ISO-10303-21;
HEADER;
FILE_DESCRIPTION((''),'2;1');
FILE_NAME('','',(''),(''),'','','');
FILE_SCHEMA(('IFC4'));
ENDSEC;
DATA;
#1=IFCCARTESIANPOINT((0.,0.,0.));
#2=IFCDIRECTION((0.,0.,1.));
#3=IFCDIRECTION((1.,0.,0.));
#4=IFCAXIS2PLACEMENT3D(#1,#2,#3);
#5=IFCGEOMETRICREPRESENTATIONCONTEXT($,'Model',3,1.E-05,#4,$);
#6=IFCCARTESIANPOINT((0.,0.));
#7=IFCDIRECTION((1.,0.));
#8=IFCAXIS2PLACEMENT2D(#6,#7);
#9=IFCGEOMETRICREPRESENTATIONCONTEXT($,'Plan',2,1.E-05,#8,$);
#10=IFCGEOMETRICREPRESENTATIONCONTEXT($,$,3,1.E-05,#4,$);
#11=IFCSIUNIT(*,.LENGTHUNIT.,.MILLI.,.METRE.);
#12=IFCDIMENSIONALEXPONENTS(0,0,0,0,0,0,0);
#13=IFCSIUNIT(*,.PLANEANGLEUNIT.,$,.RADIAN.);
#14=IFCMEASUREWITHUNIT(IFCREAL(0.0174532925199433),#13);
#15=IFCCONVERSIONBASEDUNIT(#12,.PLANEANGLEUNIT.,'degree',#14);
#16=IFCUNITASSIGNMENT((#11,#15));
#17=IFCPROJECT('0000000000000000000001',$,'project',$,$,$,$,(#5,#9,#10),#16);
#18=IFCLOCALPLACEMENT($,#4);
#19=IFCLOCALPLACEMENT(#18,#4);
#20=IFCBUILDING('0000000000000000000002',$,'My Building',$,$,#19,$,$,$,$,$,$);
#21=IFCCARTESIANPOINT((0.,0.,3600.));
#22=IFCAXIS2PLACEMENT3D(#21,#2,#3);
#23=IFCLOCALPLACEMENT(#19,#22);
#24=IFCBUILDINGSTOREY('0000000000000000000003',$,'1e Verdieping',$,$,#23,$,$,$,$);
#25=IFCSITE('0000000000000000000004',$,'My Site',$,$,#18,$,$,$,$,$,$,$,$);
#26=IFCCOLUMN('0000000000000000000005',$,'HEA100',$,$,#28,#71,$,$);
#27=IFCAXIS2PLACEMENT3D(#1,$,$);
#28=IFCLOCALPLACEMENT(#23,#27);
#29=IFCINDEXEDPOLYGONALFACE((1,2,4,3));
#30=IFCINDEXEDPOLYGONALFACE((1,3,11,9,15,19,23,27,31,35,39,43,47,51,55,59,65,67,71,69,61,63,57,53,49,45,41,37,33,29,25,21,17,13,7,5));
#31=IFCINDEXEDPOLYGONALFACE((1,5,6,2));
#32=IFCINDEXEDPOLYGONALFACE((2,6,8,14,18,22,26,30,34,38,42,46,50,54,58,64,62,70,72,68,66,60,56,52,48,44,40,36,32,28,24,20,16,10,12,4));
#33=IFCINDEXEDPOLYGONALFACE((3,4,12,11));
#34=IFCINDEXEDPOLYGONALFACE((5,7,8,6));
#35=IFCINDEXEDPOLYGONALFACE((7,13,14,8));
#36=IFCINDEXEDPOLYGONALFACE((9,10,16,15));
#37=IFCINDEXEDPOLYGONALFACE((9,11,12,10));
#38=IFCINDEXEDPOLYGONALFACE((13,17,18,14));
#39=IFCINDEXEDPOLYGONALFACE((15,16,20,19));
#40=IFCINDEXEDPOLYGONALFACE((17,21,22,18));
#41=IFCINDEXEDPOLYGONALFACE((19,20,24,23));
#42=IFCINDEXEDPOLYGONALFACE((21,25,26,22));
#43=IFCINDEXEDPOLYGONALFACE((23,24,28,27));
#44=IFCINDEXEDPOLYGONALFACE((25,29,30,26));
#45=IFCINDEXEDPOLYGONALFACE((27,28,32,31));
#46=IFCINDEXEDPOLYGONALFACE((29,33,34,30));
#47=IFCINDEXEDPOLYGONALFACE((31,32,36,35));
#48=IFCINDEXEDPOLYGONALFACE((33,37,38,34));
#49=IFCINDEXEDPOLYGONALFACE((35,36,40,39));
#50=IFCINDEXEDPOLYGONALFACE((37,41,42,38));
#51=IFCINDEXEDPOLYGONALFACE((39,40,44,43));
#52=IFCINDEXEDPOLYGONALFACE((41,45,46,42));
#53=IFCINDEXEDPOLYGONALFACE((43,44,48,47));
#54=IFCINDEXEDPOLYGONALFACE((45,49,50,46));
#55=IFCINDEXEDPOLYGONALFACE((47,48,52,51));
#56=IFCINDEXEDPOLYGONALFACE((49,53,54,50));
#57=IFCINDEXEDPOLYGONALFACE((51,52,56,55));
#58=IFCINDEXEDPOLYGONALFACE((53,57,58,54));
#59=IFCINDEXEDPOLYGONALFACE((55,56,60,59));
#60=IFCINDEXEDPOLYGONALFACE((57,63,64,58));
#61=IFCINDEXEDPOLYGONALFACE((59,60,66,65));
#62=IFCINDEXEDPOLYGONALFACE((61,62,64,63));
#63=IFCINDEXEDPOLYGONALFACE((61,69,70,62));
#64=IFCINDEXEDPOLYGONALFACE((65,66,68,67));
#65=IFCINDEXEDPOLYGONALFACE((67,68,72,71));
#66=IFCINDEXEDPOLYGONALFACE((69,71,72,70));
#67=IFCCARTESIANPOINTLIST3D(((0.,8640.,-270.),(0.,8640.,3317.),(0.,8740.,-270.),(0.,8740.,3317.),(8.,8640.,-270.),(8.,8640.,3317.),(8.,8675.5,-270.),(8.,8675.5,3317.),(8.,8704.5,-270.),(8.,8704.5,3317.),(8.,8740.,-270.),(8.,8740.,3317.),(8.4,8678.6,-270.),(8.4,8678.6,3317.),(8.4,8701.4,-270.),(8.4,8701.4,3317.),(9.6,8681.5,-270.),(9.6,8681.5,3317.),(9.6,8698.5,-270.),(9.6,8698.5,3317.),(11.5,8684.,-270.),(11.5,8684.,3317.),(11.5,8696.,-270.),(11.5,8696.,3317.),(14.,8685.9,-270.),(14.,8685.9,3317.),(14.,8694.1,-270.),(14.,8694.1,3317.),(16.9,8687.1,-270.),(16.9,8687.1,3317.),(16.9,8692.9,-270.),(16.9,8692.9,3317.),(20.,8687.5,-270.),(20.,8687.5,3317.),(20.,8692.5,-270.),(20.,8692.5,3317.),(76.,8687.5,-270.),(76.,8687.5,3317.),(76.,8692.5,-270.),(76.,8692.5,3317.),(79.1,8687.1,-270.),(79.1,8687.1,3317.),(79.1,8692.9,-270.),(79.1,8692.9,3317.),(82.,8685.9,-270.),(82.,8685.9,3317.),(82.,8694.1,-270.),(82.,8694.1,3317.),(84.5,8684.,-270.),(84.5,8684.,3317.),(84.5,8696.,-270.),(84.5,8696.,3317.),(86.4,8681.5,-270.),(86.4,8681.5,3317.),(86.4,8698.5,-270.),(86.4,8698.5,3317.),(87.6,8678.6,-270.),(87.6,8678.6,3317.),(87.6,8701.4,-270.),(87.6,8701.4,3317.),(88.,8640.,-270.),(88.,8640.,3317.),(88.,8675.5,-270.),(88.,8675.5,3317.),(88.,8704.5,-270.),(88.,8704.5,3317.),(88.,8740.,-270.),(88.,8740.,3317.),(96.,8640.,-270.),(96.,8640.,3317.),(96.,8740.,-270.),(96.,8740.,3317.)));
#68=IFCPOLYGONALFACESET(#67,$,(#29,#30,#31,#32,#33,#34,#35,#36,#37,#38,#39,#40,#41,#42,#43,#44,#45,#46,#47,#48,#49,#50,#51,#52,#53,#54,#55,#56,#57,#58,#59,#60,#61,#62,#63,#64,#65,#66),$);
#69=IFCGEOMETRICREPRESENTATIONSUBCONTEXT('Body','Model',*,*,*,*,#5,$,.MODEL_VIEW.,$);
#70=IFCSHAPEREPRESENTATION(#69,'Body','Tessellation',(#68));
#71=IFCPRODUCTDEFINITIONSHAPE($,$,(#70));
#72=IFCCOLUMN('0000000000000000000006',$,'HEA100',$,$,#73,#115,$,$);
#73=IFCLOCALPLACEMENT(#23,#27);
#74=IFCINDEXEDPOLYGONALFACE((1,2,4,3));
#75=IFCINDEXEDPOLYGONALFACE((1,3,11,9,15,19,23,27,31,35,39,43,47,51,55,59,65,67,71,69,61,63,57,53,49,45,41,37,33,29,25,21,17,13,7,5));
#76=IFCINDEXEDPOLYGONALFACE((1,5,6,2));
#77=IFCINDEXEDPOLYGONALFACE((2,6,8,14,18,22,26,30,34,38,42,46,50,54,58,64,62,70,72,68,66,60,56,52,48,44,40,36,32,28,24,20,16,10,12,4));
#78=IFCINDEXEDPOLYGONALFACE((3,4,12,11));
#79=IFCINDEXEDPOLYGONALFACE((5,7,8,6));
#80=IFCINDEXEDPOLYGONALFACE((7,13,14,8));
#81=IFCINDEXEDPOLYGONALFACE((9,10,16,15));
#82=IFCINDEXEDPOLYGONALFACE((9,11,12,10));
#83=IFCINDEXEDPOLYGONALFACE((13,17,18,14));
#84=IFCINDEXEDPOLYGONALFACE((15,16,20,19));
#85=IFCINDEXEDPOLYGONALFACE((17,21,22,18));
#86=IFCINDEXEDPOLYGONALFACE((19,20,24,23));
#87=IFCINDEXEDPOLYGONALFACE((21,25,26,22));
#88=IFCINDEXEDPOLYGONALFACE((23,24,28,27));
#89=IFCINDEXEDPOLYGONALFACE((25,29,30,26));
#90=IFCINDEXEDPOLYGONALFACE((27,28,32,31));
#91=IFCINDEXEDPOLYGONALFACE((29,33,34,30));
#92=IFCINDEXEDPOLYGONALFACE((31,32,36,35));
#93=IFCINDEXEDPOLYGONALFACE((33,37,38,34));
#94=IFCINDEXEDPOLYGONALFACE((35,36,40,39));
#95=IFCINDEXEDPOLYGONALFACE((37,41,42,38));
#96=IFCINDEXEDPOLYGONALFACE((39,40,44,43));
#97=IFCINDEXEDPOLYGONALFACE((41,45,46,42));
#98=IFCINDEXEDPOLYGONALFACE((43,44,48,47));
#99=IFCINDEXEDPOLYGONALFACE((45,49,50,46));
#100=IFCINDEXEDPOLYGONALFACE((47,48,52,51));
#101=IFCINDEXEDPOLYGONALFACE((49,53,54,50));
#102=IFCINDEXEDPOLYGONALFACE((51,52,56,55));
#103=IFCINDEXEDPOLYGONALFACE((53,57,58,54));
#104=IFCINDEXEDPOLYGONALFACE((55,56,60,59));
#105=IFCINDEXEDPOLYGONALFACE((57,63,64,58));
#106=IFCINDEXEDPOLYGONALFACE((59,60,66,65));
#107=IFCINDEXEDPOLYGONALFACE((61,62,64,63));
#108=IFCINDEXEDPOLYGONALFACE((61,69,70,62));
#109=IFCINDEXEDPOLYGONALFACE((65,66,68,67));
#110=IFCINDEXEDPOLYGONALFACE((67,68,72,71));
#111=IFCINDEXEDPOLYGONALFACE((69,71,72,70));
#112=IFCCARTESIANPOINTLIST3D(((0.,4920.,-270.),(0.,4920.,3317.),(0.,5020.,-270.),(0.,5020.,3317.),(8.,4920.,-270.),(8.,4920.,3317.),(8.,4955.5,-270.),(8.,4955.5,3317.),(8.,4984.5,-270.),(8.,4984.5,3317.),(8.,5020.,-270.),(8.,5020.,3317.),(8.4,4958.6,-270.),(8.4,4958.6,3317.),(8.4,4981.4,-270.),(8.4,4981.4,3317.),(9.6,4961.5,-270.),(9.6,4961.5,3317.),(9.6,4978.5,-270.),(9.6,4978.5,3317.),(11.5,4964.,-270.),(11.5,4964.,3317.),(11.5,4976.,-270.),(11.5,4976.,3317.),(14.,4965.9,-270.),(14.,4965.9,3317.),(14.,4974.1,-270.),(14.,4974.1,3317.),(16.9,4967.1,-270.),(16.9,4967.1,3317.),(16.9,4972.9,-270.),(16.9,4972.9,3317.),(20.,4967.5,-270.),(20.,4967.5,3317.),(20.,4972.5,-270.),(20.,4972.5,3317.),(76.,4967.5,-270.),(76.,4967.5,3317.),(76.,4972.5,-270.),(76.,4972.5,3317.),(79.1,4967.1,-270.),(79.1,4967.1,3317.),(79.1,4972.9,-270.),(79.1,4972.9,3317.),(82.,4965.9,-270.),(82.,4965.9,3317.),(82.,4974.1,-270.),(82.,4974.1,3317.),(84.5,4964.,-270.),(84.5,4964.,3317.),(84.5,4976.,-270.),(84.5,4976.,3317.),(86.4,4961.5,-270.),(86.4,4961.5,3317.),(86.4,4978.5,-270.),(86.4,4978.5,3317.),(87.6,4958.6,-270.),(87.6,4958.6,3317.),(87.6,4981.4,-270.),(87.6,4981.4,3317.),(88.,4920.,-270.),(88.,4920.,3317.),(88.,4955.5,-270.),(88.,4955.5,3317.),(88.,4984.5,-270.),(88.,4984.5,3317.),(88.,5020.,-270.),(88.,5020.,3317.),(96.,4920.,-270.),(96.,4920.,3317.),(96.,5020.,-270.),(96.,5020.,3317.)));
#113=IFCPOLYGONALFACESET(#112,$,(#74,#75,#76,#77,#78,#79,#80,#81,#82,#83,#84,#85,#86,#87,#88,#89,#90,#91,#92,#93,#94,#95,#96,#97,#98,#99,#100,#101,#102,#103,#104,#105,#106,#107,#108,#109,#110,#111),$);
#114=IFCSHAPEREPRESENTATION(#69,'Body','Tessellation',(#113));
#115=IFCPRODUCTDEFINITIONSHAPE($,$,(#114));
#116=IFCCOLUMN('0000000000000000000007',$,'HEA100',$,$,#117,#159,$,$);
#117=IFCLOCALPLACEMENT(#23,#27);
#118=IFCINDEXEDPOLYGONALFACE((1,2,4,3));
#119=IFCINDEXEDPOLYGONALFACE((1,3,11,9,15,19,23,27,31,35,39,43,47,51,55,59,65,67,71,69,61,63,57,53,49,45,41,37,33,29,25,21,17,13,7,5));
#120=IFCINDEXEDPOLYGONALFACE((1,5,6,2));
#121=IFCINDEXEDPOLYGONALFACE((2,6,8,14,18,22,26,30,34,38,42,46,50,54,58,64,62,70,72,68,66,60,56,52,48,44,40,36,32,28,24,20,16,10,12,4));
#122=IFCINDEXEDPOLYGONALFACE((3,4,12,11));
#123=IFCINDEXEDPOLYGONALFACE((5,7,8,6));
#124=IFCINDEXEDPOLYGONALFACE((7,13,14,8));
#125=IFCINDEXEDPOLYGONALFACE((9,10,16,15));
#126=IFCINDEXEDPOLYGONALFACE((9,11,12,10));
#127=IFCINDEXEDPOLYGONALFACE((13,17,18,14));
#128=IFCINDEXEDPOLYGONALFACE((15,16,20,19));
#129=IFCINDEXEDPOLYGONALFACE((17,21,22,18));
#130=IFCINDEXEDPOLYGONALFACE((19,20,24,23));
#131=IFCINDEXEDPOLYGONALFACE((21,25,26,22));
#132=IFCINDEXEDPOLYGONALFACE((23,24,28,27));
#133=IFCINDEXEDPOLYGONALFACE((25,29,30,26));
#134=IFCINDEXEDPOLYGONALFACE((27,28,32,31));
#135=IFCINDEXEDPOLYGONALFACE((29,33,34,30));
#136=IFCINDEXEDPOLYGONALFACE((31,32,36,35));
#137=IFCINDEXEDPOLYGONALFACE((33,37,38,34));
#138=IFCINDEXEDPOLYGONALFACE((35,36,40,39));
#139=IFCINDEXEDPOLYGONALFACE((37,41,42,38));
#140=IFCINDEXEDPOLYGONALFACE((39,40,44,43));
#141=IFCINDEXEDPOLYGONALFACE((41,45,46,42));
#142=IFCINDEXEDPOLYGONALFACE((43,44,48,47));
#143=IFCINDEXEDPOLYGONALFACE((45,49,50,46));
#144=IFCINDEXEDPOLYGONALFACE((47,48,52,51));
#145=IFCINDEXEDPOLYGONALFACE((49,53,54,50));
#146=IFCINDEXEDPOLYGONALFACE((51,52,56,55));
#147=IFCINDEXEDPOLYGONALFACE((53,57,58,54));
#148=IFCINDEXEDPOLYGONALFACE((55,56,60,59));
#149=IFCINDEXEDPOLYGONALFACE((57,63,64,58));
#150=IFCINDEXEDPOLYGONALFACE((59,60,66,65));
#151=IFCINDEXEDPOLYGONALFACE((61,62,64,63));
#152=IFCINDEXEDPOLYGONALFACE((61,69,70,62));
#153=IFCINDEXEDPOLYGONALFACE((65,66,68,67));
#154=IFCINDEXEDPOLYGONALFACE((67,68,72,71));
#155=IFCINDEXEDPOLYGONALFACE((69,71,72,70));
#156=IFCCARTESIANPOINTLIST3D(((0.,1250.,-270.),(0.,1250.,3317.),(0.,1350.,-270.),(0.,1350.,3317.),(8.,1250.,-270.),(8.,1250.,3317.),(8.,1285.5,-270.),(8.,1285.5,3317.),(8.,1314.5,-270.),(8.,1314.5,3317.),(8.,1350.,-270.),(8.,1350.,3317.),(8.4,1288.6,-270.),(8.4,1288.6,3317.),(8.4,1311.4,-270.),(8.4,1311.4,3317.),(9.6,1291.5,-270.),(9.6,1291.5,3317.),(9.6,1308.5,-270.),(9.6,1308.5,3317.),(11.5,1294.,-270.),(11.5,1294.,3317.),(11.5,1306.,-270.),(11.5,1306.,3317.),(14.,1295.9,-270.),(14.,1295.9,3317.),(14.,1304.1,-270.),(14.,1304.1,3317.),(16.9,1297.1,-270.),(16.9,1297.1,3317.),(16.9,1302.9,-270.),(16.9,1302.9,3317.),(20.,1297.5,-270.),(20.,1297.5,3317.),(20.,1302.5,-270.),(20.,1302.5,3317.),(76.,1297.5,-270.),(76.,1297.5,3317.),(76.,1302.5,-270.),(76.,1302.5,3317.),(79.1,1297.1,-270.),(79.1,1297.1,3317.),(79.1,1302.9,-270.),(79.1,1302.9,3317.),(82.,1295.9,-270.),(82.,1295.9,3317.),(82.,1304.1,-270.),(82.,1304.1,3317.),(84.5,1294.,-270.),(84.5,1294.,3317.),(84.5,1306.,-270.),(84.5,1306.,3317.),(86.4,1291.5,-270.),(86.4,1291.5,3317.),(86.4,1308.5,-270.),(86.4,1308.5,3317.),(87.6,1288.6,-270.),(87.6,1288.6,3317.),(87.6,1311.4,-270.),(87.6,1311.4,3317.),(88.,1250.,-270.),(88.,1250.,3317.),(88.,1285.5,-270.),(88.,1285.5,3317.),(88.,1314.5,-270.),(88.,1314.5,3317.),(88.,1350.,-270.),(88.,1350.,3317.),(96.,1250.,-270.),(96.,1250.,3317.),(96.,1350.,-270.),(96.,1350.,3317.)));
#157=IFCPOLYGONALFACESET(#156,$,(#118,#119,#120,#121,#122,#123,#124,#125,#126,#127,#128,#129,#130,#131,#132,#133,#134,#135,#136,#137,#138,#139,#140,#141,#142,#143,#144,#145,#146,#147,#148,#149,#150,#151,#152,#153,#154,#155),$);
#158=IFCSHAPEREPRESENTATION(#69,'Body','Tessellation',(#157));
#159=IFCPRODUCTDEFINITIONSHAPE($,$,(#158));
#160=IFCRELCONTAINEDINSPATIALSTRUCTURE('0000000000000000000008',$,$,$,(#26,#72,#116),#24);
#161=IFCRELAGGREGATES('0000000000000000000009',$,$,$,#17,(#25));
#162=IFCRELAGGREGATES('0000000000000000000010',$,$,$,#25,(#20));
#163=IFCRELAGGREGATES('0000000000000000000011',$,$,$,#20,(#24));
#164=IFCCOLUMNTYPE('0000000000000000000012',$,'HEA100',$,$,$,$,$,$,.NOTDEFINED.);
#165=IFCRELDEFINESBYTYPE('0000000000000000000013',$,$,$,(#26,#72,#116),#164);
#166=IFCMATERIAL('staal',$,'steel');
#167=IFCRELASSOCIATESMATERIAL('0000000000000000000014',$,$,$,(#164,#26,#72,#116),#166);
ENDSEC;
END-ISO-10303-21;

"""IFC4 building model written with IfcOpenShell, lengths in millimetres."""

from ifc_helpers import new_model, entity, si_unit, converted_unit, frame, origin_with_axes, origin_2d_with_axis, place, context, subcontext, project, spatial, i_section, extrude, material, material_profile, profile_set, profile_usage, type_object, element, save


model = new_model("IFC4")

# Units and contexts
model_context = context("Model", 3, precision=1e-05, world=origin_with_axes())
plan_context = context("Plan", 2, precision=1e-05, world=origin_2d_with_axis())
context_of_model = context(None, 3, precision=1e-05, world=origin_with_axes())
body_context = subcontext(model_context, "Body", "Model", "MODEL_VIEW")
ifc_project = project(units=[si_unit("LENGTHUNIT", "METRE", prefix="MILLI"), converted_unit("PLANEANGLEUNIT", "degree", entity("IfcReal", 0.0174532925199433), si_unit("PLANEANGLEUNIT", "RADIAN"), dimensions=[0, 0, 0, 0, 0, 0, 0])], contexts=[model_context, plan_context, context_of_model])

# Site, building, storey
site_placement = place(None, origin_with_axes())
site = spatial("IfcSite", under=ifc_project, at=site_placement, Name="My Site")
building_placement = place(site_placement, origin_with_axes())
building = spatial("IfcBuilding", under=site, at=building_placement, Name="My Building")
storey_placement = place(building_placement, frame((0.0, 0.0, 3600.0), z_axis=(0.0, 0.0, 1.0), x_axis=(1.0, 0.0, 0.0)))
storey = spatial("IfcBuildingStorey", under=building, at=storey_placement, Name="1e Verdieping")

# Shared definitions
ifc_material = material(Name="staal", Category="steel")
ifc_material_profile_1 = material_profile(ifc_material, i_section(OverallWidth=100.0, OverallDepth=96.0, WebThickness=5.0, FlangeThickness=8.0, FilletRadius=12.0))
ifc_profile_set_1 = profile_set([ifc_material_profile_1], Name="HEA100")
column_type_1 = type_object("IfcColumnType", Name="HEA100", PredefinedType="NOTDEFINED", material=ifc_profile_set_1)

# Columns
ifc_profile_usage_1 = profile_usage(ifc_profile_set_1)
column_1_placement = place(storey_placement, frame((48.0, 8690.0, -270.0), z_axis=(0.0, 0.0, 1.0), x_axis=(0.0, 1.0, 0.0)))
element("IfcColumn", 1, at=column_1_placement, inside=storey, type_object=column_type_1, material=ifc_profile_usage_1, Name="HEA100", context=body_context, shape_type="SweptSolid", body=[
    extrude(i_section(OverallWidth=100.0, OverallDepth=96.0, WebThickness=5.0, FlangeThickness=8.0, FilletRadius=12.0), origin_with_axes(), (0.0, 0.0, 1.0), 3587.0),
])
ifc_profile_usage_2 = profile_usage(ifc_profile_set_1)
column_2_placement = place(storey_placement, frame((48.0, 4970.0, -270.0), z_axis=(0.0, 0.0, 1.0), x_axis=(0.0, 1.0, 0.0)))
element("IfcColumn", 2, at=column_2_placement, inside=storey, type_object=column_type_1, material=ifc_profile_usage_2, Name="HEA100", context=body_context, shape_type="SweptSolid", body=[
    extrude(i_section(OverallWidth=100.0, OverallDepth=96.0, WebThickness=5.0, FlangeThickness=8.0, FilletRadius=12.0), origin_with_axes(), (0.0, 0.0, 1.0), 3587.0),
])
ifc_profile_usage_3 = profile_usage(ifc_profile_set_1)
column_3_placement = place(storey_placement, frame((48.0, 1300.0, -270.0), z_axis=(0.0, 0.0, 1.0), x_axis=(0.0, 1.0, 0.0)))
element("IfcColumn", 3, at=column_3_placement, inside=storey, type_object=column_type_1, material=ifc_profile_usage_3, Name="HEA100", context=body_context, shape_type="SweptSolid", body=[
    extrude(i_section(OverallWidth=100.0, OverallDepth=96.0, WebThickness=5.0, FlangeThickness=8.0, FilletRadius=12.0), origin_with_axes(), (0.0, 0.0, 1.0), 3587.0),
])

save(model, "model.ifc")
